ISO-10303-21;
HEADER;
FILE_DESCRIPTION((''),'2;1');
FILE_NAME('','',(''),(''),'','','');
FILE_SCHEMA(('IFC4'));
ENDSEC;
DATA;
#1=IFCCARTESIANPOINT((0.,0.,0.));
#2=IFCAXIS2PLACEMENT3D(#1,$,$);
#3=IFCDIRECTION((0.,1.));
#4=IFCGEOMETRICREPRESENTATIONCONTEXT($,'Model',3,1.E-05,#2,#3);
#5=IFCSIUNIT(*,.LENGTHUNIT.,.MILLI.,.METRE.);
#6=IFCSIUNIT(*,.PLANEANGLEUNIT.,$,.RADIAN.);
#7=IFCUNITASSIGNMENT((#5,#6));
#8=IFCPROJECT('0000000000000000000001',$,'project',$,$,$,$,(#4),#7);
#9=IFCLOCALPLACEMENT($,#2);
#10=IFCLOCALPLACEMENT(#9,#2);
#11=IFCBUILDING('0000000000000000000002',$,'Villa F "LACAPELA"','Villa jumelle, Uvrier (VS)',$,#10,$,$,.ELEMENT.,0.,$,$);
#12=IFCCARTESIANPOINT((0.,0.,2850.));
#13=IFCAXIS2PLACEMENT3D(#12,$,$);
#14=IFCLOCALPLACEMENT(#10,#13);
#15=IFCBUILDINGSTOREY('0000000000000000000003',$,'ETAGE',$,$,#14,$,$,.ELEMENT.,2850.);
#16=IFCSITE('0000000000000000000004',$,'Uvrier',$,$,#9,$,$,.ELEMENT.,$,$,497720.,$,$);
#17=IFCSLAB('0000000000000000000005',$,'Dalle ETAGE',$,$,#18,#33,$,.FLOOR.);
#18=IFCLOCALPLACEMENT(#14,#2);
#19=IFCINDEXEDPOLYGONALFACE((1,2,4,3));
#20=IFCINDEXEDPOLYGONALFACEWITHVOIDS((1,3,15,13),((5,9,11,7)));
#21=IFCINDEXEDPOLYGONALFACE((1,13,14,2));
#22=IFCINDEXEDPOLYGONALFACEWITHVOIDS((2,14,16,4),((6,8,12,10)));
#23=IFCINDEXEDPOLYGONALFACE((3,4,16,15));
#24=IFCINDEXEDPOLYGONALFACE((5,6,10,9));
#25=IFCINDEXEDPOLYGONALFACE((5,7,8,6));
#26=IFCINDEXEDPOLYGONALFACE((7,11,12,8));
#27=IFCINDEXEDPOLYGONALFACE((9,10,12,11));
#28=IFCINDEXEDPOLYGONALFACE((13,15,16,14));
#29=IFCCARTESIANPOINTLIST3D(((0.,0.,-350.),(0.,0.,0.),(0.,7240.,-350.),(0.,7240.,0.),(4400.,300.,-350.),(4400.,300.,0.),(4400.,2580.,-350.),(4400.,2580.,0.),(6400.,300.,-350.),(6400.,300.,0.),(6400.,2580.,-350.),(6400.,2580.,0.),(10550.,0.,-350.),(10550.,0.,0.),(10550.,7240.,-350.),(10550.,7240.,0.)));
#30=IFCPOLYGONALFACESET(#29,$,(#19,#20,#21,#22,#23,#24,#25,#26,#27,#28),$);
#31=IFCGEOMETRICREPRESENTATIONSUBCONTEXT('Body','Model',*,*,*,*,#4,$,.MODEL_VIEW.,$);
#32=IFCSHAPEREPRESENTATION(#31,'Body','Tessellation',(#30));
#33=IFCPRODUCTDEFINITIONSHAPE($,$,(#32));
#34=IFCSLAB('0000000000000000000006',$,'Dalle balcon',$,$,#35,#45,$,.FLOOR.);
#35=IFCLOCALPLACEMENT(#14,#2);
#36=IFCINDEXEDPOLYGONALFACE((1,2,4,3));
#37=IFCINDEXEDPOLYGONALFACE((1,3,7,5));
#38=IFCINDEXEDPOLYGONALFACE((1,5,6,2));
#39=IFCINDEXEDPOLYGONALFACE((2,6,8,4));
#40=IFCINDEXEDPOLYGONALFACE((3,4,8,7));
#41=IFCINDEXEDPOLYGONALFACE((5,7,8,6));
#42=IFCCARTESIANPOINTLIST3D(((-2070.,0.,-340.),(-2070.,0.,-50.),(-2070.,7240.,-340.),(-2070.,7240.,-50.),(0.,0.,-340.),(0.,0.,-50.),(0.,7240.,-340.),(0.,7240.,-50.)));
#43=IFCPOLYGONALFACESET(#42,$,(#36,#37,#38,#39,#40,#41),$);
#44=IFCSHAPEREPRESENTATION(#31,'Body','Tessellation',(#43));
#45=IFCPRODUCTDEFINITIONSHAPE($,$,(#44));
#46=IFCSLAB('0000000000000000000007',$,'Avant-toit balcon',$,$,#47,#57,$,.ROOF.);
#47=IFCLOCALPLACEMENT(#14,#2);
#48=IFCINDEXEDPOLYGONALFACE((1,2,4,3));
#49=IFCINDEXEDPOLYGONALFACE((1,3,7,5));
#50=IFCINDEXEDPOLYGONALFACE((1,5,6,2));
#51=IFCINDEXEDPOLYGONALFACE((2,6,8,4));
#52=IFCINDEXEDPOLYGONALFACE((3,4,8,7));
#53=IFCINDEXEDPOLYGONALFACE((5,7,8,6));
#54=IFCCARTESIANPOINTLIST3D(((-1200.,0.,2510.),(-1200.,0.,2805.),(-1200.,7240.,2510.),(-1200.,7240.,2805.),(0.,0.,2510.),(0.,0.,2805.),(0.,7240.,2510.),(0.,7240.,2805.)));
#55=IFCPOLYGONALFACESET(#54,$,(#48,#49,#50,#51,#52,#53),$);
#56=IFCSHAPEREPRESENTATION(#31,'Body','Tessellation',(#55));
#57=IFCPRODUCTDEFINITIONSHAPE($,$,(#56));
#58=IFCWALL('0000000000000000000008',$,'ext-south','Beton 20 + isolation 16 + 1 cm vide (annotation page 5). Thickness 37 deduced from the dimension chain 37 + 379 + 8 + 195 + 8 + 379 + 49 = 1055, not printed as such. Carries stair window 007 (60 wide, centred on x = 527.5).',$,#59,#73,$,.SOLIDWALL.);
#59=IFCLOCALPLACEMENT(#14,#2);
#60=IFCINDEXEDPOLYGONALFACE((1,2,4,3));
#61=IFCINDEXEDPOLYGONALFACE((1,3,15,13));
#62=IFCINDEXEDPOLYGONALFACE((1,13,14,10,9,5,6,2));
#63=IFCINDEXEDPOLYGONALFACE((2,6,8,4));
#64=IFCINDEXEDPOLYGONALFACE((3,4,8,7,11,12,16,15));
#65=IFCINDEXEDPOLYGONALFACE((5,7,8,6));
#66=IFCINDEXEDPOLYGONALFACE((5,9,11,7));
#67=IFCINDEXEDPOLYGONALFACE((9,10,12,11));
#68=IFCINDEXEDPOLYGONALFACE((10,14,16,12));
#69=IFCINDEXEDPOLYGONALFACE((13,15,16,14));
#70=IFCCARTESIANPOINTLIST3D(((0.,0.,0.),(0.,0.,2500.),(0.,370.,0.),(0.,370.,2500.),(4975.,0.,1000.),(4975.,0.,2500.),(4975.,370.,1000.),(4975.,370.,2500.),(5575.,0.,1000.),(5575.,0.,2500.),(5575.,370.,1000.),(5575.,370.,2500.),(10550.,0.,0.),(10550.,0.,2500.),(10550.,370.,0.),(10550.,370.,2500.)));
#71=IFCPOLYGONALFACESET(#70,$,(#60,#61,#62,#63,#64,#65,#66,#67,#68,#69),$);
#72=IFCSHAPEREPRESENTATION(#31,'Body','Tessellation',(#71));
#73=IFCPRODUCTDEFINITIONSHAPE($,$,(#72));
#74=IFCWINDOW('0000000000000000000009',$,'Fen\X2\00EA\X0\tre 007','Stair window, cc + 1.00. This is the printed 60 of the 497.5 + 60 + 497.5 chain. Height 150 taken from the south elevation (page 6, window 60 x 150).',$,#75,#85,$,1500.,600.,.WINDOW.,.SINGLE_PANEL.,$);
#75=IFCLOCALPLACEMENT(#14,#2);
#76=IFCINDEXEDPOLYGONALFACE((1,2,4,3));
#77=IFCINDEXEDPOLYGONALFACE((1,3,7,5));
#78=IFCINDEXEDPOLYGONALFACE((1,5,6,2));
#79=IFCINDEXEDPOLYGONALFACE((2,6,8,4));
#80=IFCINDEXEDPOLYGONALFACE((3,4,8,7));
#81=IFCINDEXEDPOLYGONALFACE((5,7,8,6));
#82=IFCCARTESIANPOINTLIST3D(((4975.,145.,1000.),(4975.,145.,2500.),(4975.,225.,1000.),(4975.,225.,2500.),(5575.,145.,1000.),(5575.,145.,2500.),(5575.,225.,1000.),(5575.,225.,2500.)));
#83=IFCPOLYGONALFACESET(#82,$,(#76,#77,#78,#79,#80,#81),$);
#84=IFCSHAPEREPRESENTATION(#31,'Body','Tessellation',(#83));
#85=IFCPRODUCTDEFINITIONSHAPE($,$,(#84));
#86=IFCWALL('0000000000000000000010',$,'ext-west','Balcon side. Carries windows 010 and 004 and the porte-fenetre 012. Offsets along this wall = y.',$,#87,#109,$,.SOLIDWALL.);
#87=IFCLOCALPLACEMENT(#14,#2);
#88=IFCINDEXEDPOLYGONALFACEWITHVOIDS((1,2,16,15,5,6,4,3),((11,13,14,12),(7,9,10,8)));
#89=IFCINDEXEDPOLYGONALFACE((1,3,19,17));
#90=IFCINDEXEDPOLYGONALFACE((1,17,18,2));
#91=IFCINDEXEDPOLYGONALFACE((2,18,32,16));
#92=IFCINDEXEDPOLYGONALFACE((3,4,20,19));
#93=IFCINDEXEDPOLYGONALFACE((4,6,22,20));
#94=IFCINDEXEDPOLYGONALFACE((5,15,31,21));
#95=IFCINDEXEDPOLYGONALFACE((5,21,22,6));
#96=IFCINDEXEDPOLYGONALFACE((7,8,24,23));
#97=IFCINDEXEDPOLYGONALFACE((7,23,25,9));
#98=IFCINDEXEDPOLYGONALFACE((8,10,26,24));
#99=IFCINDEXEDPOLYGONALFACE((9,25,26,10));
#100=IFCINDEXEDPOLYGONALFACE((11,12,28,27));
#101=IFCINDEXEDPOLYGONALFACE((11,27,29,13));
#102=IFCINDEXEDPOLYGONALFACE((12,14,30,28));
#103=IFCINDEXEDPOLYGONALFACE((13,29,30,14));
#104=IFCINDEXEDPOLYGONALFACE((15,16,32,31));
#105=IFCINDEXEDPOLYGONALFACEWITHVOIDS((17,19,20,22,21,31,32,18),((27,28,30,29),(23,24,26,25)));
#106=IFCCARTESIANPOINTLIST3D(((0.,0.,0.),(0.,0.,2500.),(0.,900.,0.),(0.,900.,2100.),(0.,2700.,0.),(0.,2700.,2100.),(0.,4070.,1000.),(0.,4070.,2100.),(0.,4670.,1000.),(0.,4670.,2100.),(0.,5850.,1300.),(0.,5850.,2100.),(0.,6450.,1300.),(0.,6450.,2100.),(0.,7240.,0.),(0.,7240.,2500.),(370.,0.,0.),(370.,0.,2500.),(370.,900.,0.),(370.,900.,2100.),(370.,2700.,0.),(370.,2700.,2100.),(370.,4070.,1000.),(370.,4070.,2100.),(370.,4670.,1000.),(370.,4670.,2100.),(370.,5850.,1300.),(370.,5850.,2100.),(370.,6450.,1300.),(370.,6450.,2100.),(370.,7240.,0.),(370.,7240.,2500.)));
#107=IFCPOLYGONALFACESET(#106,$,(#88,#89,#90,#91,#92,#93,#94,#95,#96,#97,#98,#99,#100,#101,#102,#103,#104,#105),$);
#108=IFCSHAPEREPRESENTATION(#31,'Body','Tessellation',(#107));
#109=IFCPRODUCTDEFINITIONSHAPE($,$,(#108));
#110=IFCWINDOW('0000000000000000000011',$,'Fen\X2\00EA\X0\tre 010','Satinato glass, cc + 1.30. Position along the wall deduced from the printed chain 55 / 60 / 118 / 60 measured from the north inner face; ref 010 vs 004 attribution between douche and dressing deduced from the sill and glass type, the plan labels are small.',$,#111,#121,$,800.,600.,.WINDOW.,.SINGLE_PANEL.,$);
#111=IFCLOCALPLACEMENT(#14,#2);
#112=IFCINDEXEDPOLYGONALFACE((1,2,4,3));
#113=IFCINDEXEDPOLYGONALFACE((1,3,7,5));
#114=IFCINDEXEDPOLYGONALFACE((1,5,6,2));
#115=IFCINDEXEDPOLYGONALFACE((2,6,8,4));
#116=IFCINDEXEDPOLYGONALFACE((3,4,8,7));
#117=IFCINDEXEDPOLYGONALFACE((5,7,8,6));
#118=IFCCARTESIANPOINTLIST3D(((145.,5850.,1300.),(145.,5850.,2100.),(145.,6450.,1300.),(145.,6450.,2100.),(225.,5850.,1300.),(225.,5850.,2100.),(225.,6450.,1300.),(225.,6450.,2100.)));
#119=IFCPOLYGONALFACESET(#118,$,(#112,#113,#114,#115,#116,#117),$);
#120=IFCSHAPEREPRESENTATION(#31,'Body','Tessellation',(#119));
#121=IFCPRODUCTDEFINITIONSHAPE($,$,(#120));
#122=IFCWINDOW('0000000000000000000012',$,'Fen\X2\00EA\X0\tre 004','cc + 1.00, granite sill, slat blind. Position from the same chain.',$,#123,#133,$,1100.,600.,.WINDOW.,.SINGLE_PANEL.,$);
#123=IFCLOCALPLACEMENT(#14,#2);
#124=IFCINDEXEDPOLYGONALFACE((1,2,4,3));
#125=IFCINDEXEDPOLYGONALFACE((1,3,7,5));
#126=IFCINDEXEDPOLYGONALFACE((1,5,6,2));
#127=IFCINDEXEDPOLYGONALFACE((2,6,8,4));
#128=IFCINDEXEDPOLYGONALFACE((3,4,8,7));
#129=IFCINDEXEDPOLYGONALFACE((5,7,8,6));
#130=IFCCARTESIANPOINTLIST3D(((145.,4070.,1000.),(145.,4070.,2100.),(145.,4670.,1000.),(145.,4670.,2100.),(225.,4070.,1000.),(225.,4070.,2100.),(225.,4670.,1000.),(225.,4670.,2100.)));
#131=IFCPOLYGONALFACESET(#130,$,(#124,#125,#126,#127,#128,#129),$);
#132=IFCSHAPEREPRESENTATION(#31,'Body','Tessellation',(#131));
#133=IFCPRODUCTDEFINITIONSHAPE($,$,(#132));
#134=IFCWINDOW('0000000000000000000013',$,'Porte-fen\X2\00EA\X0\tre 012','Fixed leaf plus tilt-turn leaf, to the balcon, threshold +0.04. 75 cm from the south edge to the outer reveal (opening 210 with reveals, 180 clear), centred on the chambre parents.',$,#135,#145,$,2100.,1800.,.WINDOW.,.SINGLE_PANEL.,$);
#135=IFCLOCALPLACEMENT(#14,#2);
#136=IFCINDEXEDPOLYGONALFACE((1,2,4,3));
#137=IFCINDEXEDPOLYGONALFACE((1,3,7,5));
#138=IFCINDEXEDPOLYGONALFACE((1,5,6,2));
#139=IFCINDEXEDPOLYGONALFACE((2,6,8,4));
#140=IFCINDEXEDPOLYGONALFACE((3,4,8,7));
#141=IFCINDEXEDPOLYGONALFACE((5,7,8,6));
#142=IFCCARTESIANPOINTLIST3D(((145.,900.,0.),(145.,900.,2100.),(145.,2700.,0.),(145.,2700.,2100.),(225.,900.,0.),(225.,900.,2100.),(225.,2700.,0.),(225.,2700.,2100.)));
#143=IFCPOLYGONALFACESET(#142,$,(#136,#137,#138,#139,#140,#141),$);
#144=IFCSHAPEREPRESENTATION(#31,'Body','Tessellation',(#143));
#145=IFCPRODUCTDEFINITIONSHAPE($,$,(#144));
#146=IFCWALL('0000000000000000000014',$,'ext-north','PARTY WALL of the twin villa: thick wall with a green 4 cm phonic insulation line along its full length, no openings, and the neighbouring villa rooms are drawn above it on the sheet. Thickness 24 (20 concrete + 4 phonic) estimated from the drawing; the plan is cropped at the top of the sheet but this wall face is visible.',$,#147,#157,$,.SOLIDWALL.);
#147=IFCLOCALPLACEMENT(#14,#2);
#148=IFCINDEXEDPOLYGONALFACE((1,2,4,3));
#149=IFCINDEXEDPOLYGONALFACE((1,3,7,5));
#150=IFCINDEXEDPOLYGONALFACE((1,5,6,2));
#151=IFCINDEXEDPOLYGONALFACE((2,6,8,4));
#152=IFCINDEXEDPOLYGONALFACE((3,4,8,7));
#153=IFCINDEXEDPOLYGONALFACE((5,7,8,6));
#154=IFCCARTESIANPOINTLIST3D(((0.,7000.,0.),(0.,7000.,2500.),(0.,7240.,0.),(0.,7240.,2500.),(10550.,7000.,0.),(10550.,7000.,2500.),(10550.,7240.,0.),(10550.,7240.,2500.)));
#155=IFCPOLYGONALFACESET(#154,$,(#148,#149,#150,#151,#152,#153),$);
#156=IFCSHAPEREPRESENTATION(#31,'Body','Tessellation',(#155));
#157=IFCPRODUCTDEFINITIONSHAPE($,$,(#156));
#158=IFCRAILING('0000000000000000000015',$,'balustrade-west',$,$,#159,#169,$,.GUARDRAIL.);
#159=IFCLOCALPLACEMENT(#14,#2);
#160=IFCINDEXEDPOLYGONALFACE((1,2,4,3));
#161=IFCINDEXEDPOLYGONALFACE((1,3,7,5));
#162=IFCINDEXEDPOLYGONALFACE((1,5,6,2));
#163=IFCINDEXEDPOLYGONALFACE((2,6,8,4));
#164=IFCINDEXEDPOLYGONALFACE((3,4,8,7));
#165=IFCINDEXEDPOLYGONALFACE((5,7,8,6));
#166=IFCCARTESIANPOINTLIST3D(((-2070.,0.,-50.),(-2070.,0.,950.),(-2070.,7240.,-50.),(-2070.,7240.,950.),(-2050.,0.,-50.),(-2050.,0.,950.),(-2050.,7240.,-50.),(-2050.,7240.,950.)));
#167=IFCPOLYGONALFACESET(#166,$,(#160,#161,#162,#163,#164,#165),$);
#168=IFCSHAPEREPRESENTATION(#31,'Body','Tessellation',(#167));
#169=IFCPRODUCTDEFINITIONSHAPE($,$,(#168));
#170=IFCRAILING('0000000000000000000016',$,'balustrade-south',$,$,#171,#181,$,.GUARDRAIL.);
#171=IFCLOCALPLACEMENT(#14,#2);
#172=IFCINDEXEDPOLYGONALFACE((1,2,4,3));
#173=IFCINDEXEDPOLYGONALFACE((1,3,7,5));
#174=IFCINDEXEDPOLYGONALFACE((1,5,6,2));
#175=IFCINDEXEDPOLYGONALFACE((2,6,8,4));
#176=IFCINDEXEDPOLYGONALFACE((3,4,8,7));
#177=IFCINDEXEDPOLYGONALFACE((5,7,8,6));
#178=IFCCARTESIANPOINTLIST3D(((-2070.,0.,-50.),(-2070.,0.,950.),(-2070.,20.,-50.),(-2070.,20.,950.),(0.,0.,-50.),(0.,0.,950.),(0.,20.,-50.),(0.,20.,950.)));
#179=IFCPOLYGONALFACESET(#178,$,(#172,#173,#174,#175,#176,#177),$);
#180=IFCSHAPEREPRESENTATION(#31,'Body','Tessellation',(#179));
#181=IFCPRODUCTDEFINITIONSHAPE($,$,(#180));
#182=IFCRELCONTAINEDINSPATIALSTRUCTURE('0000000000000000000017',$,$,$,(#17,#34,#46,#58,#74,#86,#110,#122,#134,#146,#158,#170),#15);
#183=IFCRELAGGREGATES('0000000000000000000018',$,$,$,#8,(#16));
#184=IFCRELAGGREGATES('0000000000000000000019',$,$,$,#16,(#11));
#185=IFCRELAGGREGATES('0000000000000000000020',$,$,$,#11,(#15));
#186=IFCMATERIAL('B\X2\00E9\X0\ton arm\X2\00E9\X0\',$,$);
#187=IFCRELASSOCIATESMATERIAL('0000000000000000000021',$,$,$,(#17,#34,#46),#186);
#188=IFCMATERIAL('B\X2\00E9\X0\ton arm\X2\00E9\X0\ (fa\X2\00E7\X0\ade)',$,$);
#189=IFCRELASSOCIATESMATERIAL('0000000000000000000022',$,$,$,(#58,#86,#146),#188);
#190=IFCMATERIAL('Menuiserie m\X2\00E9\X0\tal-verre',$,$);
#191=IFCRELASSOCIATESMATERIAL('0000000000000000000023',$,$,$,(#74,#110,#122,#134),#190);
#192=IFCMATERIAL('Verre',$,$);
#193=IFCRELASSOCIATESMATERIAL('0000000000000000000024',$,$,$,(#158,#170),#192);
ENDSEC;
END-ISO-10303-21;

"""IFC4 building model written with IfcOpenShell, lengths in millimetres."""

from ifc_helpers import new_model, si_unit, direction, frame, frame_2d, origin, place, context, subcontext, project, spatial, polyline, rectangle, outline, extrude, material, element, fill, save


model = new_model("IFC4")

# Units and contexts
model_context = context("Model", 3, precision=1e-05, world=origin(), true_north=direction((0.0, 1.0)))
body_context = subcontext(model_context, "Body", "Model", "MODEL_VIEW")
ifc_project = project(units=[si_unit("LENGTHUNIT", "METRE", prefix="MILLI"), si_unit("PLANEANGLEUNIT", "RADIAN")], contexts=[model_context])

# Site, building, storey
site_placement = place(None, origin())
site = spatial("IfcSite", under=ifc_project, at=site_placement, Name="Uvrier", CompositionType="ELEMENT", RefElevation=497720.0)
building_placement = place(site_placement, origin())
building = spatial("IfcBuilding", under=site, at=building_placement, Name="Villa F \"LACAPELA\"", Description="Villa jumelle, Uvrier (VS)", CompositionType="ELEMENT", ElevationOfRefHeight=0.0)
storey_placement = place(building_placement, frame((0.0, 0.0, 2850.0)))
storey = spatial("IfcBuildingStorey", under=building, at=storey_placement, Name="ETAGE", CompositionType="ELEMENT", Elevation=2850.0)

# Slabs
ifc_material_1 = material(Name="Béton armé")
slab_1_placement = place(storey_placement, origin())
element("IfcSlab", 1, at=slab_1_placement, inside=storey, material=ifc_material_1, Name="Dalle ETAGE", PredefinedType="FLOOR", context=body_context, shape_type="SweptSolid", body=[
    extrude(outline(polyline([(0.0, 0.0), (10550.0, 0.0), (10550.0, 7240.0), (0.0, 7240.0), (0.0, 0.0)]), holes=[polyline([(4400.0, 300.0), (6400.0, 300.0), (6400.0, 2580.0), (4400.0, 2580.0), (4400.0, 300.0)])]), frame((0.0, 0.0, -350.0)), (0.0, 0.0, 1.0), 350.0),
])
slab_2_placement = place(storey_placement, origin())
element("IfcSlab", 2, at=slab_2_placement, inside=storey, material=ifc_material_1, Name="Dalle balcon", PredefinedType="FLOOR", context=body_context, shape_type="SweptSolid", body=[
    extrude(outline(polyline([(-2070.0, 0.0), (0.0, 0.0), (0.0, 7240.0), (-2070.0, 7240.0), (-2070.0, 0.0)])), frame((0.0, 0.0, -340.0)), (0.0, 0.0, 1.0), 290.0),
])
slab_3_placement = place(storey_placement, origin())
element("IfcSlab", 3, at=slab_3_placement, inside=storey, material=ifc_material_1, Name="Avant-toit balcon", PredefinedType="ROOF", context=body_context, shape_type="SweptSolid", body=[
    extrude(outline(polyline([(-1200.0, 0.0), (0.0, 0.0), (0.0, 7240.0), (-1200.0, 7240.0), (-1200.0, 0.0)])), frame((0.0, 0.0, 2510.0)), (0.0, 0.0, 1.0), 295.0),
])

# Wall, opening, window
ifc_material_2 = material(Name="Béton armé (façade)")
wall_1_placement = place(storey_placement, frame((0.0, 185.0, 0.0), z_axis=(0.0, 0.0, 1.0), x_axis=(1.0, 0.0, 0.0)))
wall_1 = element("IfcWall", 4, at=wall_1_placement, inside=storey, material=ifc_material_2, Name="ext-south", Description="Beton 20 + isolation 16 + 1 cm vide (annotation page 5). Thickness 37 deduced from the dimension chain 37 + 379 + 8 + 195 + 8 + 379 + 49 = 1055, not printed as such. Carries stair window 007 (60 wide, centred on x = 527.5).", PredefinedType="SOLIDWALL", context=body_context, shape_type="SweptSolid", body=[
    extrude(rectangle(XDim=10550.0, YDim=370.0, at=frame_2d((5275.0, 0.0))), origin(), (0.0, 0.0, 1.0), 2500.0),
])
opening_1_placement = place(wall_1_placement, frame((4975.0, 0.0, 1000.0)))
opening_1 = element("IfcOpeningElement", 5, at=opening_1_placement, cuts=wall_1, PredefinedType="OPENING", context=body_context, shape_type="SweptSolid", body=[
    extrude(rectangle(XDim=600.0, YDim=570.0, at=frame_2d((300.0, 0.0))), origin(), (0.0, 0.0, 1.0), 1500.0),
])
ifc_material_3 = material(Name="Menuiserie métal-verre")
window_1_placement = place(opening_1_placement, origin())
window_1 = element("IfcWindow", 6, at=window_1_placement, inside=storey, material=ifc_material_3, Name="Fenêtre 007", Description="Stair window, cc + 1.00. This is the printed 60 of the 497.5 + 60 + 497.5 chain. Height 150 taken from the south elevation (page 6, window 60 x 150).", OverallHeight=1500.0, OverallWidth=600.0, PartitioningType="SINGLE_PANEL", PredefinedType="WINDOW", context=body_context, shape_type="SweptSolid", body=[
    extrude(rectangle(XDim=600.0, YDim=80.0, at=frame_2d((300.0, 0.0))), origin(), (0.0, 0.0, 1.0), 1500.0),
])
fill(opening_1, window_1)

# Wall, openings, windows
wall_2_placement = place(storey_placement, frame((185.0, 0.0, 0.0), z_axis=(0.0, 0.0, 1.0), x_axis=(0.0, 1.0, 0.0)))
wall_2 = element("IfcWall", 7, at=wall_2_placement, inside=storey, material=ifc_material_2, Name="ext-west", Description="Balcon side. Carries windows 010 and 004 and the porte-fenetre 012. Offsets along this wall = y.", PredefinedType="SOLIDWALL", context=body_context, shape_type="SweptSolid", body=[
    extrude(rectangle(XDim=7240.0, YDim=370.0, at=frame_2d((3620.0, 0.0))), origin(), (0.0, 0.0, 1.0), 2500.0),
])
opening_2_placement = place(wall_2_placement, frame((5850.0, 0.0, 1300.0)))
opening_2 = element("IfcOpeningElement", 8, at=opening_2_placement, cuts=wall_2, PredefinedType="OPENING", context=body_context, shape_type="SweptSolid", body=[
    extrude(rectangle(XDim=600.0, YDim=570.0, at=frame_2d((300.0, 0.0))), origin(), (0.0, 0.0, 1.0), 800.0),
])
opening_3_placement = place(wall_2_placement, frame((4070.0, 0.0, 1000.0)))
opening_3 = element("IfcOpeningElement", 9, at=opening_3_placement, cuts=wall_2, PredefinedType="OPENING", context=body_context, shape_type="SweptSolid", body=[
    extrude(rectangle(XDim=600.0, YDim=570.0, at=frame_2d((300.0, 0.0))), origin(), (0.0, 0.0, 1.0), 1100.0),
])
opening_4_placement = place(wall_2_placement, frame((900.0, 0.0, 0.0)))
opening_4 = element("IfcOpeningElement", 10, at=opening_4_placement, cuts=wall_2, PredefinedType="OPENING", context=body_context, shape_type="SweptSolid", body=[
    extrude(rectangle(XDim=1800.0, YDim=570.0, at=frame_2d((900.0, 0.0))), origin(), (0.0, 0.0, 1.0), 2100.0),
])
window_2_placement = place(opening_2_placement, origin())
window_2 = element("IfcWindow", 11, at=window_2_placement, inside=storey, material=ifc_material_3, Name="Fenêtre 010", Description="Satinato glass, cc + 1.30. Position along the wall deduced from the printed chain 55 / 60 / 118 / 60 measured from the north inner face; ref 010 vs 004 attribution between douche and dressing deduced from the sill and glass type, the plan labels are small.", OverallHeight=800.0, OverallWidth=600.0, PartitioningType="SINGLE_PANEL", PredefinedType="WINDOW", context=body_context, shape_type="SweptSolid", body=[
    extrude(rectangle(XDim=600.0, YDim=80.0, at=frame_2d((300.0, 0.0))), origin(), (0.0, 0.0, 1.0), 800.0),
])
fill(opening_2, window_2)
window_3_placement = place(opening_3_placement, origin())
window_3 = element("IfcWindow", 12, at=window_3_placement, inside=storey, material=ifc_material_3, Name="Fenêtre 004", Description="cc + 1.00, granite sill, slat blind. Position from the same chain.", OverallHeight=1100.0, OverallWidth=600.0, PartitioningType="SINGLE_PANEL", PredefinedType="WINDOW", context=body_context, shape_type="SweptSolid", body=[
    extrude(rectangle(XDim=600.0, YDim=80.0, at=frame_2d((300.0, 0.0))), origin(), (0.0, 0.0, 1.0), 1100.0),
])
fill(opening_3, window_3)
window_4_placement = place(opening_4_placement, origin())
window_4 = element("IfcWindow", 13, at=window_4_placement, inside=storey, material=ifc_material_3, Name="Porte-fenêtre 012", Description="Fixed leaf plus tilt-turn leaf, to the balcon, threshold +0.04. 75 cm from the south edge to the outer reveal (opening 210 with reveals, 180 clear), centred on the chambre parents.", OverallHeight=2100.0, OverallWidth=1800.0, PartitioningType="SINGLE_PANEL", PredefinedType="WINDOW", context=body_context, shape_type="SweptSolid", body=[
    extrude(rectangle(XDim=1800.0, YDim=80.0, at=frame_2d((900.0, 0.0))), origin(), (0.0, 0.0, 1.0), 2100.0),
])
fill(opening_4, window_4)

# Wall
wall_3_placement = place(storey_placement, frame((0.0, 7120.0, 0.0), z_axis=(0.0, 0.0, 1.0), x_axis=(1.0, 0.0, 0.0)))
element("IfcWall", 14, at=wall_3_placement, inside=storey, material=ifc_material_2, Name="ext-north", Description="PARTY WALL of the twin villa: thick wall with a green 4 cm phonic insulation line along its full length, no openings, and the neighbouring villa rooms are drawn above it on the sheet. Thickness 24 (20 concrete + 4 phonic) estimated from the drawing; the plan is cropped at the top of the sheet but this wall face is visible.", PredefinedType="SOLIDWALL", context=body_context, shape_type="SweptSolid", body=[
    extrude(rectangle(XDim=10550.0, YDim=240.0, at=frame_2d((5275.0, 0.0))), origin(), (0.0, 0.0, 1.0), 2500.0),
])

# Railings
ifc_material_4 = material(Name="Verre")
railing_1_placement = place(storey_placement, origin())
element("IfcRailing", 15, at=railing_1_placement, inside=storey, material=ifc_material_4, Name="balustrade-west", PredefinedType="GUARDRAIL", context=body_context, shape_type="SweptSolid", body=[
    extrude(rectangle(XDim=20.0, YDim=7240.0, at=frame_2d((-2060.0, 3620.0))), frame((0.0, 0.0, -50.0)), (0.0, 0.0, 1.0), 1000.0),
])
railing_2_placement = place(storey_placement, origin())
element("IfcRailing", 16, at=railing_2_placement, inside=storey, material=ifc_material_4, Name="balustrade-south", PredefinedType="GUARDRAIL", context=body_context, shape_type="SweptSolid", body=[
    extrude(rectangle(XDim=2070.0, YDim=20.0, at=frame_2d((-1035.0, 10.0))), frame((0.0, 0.0, -50.0)), (0.0, 0.0, 1.0), 1000.0),
])

save(model, "model.ifc")
